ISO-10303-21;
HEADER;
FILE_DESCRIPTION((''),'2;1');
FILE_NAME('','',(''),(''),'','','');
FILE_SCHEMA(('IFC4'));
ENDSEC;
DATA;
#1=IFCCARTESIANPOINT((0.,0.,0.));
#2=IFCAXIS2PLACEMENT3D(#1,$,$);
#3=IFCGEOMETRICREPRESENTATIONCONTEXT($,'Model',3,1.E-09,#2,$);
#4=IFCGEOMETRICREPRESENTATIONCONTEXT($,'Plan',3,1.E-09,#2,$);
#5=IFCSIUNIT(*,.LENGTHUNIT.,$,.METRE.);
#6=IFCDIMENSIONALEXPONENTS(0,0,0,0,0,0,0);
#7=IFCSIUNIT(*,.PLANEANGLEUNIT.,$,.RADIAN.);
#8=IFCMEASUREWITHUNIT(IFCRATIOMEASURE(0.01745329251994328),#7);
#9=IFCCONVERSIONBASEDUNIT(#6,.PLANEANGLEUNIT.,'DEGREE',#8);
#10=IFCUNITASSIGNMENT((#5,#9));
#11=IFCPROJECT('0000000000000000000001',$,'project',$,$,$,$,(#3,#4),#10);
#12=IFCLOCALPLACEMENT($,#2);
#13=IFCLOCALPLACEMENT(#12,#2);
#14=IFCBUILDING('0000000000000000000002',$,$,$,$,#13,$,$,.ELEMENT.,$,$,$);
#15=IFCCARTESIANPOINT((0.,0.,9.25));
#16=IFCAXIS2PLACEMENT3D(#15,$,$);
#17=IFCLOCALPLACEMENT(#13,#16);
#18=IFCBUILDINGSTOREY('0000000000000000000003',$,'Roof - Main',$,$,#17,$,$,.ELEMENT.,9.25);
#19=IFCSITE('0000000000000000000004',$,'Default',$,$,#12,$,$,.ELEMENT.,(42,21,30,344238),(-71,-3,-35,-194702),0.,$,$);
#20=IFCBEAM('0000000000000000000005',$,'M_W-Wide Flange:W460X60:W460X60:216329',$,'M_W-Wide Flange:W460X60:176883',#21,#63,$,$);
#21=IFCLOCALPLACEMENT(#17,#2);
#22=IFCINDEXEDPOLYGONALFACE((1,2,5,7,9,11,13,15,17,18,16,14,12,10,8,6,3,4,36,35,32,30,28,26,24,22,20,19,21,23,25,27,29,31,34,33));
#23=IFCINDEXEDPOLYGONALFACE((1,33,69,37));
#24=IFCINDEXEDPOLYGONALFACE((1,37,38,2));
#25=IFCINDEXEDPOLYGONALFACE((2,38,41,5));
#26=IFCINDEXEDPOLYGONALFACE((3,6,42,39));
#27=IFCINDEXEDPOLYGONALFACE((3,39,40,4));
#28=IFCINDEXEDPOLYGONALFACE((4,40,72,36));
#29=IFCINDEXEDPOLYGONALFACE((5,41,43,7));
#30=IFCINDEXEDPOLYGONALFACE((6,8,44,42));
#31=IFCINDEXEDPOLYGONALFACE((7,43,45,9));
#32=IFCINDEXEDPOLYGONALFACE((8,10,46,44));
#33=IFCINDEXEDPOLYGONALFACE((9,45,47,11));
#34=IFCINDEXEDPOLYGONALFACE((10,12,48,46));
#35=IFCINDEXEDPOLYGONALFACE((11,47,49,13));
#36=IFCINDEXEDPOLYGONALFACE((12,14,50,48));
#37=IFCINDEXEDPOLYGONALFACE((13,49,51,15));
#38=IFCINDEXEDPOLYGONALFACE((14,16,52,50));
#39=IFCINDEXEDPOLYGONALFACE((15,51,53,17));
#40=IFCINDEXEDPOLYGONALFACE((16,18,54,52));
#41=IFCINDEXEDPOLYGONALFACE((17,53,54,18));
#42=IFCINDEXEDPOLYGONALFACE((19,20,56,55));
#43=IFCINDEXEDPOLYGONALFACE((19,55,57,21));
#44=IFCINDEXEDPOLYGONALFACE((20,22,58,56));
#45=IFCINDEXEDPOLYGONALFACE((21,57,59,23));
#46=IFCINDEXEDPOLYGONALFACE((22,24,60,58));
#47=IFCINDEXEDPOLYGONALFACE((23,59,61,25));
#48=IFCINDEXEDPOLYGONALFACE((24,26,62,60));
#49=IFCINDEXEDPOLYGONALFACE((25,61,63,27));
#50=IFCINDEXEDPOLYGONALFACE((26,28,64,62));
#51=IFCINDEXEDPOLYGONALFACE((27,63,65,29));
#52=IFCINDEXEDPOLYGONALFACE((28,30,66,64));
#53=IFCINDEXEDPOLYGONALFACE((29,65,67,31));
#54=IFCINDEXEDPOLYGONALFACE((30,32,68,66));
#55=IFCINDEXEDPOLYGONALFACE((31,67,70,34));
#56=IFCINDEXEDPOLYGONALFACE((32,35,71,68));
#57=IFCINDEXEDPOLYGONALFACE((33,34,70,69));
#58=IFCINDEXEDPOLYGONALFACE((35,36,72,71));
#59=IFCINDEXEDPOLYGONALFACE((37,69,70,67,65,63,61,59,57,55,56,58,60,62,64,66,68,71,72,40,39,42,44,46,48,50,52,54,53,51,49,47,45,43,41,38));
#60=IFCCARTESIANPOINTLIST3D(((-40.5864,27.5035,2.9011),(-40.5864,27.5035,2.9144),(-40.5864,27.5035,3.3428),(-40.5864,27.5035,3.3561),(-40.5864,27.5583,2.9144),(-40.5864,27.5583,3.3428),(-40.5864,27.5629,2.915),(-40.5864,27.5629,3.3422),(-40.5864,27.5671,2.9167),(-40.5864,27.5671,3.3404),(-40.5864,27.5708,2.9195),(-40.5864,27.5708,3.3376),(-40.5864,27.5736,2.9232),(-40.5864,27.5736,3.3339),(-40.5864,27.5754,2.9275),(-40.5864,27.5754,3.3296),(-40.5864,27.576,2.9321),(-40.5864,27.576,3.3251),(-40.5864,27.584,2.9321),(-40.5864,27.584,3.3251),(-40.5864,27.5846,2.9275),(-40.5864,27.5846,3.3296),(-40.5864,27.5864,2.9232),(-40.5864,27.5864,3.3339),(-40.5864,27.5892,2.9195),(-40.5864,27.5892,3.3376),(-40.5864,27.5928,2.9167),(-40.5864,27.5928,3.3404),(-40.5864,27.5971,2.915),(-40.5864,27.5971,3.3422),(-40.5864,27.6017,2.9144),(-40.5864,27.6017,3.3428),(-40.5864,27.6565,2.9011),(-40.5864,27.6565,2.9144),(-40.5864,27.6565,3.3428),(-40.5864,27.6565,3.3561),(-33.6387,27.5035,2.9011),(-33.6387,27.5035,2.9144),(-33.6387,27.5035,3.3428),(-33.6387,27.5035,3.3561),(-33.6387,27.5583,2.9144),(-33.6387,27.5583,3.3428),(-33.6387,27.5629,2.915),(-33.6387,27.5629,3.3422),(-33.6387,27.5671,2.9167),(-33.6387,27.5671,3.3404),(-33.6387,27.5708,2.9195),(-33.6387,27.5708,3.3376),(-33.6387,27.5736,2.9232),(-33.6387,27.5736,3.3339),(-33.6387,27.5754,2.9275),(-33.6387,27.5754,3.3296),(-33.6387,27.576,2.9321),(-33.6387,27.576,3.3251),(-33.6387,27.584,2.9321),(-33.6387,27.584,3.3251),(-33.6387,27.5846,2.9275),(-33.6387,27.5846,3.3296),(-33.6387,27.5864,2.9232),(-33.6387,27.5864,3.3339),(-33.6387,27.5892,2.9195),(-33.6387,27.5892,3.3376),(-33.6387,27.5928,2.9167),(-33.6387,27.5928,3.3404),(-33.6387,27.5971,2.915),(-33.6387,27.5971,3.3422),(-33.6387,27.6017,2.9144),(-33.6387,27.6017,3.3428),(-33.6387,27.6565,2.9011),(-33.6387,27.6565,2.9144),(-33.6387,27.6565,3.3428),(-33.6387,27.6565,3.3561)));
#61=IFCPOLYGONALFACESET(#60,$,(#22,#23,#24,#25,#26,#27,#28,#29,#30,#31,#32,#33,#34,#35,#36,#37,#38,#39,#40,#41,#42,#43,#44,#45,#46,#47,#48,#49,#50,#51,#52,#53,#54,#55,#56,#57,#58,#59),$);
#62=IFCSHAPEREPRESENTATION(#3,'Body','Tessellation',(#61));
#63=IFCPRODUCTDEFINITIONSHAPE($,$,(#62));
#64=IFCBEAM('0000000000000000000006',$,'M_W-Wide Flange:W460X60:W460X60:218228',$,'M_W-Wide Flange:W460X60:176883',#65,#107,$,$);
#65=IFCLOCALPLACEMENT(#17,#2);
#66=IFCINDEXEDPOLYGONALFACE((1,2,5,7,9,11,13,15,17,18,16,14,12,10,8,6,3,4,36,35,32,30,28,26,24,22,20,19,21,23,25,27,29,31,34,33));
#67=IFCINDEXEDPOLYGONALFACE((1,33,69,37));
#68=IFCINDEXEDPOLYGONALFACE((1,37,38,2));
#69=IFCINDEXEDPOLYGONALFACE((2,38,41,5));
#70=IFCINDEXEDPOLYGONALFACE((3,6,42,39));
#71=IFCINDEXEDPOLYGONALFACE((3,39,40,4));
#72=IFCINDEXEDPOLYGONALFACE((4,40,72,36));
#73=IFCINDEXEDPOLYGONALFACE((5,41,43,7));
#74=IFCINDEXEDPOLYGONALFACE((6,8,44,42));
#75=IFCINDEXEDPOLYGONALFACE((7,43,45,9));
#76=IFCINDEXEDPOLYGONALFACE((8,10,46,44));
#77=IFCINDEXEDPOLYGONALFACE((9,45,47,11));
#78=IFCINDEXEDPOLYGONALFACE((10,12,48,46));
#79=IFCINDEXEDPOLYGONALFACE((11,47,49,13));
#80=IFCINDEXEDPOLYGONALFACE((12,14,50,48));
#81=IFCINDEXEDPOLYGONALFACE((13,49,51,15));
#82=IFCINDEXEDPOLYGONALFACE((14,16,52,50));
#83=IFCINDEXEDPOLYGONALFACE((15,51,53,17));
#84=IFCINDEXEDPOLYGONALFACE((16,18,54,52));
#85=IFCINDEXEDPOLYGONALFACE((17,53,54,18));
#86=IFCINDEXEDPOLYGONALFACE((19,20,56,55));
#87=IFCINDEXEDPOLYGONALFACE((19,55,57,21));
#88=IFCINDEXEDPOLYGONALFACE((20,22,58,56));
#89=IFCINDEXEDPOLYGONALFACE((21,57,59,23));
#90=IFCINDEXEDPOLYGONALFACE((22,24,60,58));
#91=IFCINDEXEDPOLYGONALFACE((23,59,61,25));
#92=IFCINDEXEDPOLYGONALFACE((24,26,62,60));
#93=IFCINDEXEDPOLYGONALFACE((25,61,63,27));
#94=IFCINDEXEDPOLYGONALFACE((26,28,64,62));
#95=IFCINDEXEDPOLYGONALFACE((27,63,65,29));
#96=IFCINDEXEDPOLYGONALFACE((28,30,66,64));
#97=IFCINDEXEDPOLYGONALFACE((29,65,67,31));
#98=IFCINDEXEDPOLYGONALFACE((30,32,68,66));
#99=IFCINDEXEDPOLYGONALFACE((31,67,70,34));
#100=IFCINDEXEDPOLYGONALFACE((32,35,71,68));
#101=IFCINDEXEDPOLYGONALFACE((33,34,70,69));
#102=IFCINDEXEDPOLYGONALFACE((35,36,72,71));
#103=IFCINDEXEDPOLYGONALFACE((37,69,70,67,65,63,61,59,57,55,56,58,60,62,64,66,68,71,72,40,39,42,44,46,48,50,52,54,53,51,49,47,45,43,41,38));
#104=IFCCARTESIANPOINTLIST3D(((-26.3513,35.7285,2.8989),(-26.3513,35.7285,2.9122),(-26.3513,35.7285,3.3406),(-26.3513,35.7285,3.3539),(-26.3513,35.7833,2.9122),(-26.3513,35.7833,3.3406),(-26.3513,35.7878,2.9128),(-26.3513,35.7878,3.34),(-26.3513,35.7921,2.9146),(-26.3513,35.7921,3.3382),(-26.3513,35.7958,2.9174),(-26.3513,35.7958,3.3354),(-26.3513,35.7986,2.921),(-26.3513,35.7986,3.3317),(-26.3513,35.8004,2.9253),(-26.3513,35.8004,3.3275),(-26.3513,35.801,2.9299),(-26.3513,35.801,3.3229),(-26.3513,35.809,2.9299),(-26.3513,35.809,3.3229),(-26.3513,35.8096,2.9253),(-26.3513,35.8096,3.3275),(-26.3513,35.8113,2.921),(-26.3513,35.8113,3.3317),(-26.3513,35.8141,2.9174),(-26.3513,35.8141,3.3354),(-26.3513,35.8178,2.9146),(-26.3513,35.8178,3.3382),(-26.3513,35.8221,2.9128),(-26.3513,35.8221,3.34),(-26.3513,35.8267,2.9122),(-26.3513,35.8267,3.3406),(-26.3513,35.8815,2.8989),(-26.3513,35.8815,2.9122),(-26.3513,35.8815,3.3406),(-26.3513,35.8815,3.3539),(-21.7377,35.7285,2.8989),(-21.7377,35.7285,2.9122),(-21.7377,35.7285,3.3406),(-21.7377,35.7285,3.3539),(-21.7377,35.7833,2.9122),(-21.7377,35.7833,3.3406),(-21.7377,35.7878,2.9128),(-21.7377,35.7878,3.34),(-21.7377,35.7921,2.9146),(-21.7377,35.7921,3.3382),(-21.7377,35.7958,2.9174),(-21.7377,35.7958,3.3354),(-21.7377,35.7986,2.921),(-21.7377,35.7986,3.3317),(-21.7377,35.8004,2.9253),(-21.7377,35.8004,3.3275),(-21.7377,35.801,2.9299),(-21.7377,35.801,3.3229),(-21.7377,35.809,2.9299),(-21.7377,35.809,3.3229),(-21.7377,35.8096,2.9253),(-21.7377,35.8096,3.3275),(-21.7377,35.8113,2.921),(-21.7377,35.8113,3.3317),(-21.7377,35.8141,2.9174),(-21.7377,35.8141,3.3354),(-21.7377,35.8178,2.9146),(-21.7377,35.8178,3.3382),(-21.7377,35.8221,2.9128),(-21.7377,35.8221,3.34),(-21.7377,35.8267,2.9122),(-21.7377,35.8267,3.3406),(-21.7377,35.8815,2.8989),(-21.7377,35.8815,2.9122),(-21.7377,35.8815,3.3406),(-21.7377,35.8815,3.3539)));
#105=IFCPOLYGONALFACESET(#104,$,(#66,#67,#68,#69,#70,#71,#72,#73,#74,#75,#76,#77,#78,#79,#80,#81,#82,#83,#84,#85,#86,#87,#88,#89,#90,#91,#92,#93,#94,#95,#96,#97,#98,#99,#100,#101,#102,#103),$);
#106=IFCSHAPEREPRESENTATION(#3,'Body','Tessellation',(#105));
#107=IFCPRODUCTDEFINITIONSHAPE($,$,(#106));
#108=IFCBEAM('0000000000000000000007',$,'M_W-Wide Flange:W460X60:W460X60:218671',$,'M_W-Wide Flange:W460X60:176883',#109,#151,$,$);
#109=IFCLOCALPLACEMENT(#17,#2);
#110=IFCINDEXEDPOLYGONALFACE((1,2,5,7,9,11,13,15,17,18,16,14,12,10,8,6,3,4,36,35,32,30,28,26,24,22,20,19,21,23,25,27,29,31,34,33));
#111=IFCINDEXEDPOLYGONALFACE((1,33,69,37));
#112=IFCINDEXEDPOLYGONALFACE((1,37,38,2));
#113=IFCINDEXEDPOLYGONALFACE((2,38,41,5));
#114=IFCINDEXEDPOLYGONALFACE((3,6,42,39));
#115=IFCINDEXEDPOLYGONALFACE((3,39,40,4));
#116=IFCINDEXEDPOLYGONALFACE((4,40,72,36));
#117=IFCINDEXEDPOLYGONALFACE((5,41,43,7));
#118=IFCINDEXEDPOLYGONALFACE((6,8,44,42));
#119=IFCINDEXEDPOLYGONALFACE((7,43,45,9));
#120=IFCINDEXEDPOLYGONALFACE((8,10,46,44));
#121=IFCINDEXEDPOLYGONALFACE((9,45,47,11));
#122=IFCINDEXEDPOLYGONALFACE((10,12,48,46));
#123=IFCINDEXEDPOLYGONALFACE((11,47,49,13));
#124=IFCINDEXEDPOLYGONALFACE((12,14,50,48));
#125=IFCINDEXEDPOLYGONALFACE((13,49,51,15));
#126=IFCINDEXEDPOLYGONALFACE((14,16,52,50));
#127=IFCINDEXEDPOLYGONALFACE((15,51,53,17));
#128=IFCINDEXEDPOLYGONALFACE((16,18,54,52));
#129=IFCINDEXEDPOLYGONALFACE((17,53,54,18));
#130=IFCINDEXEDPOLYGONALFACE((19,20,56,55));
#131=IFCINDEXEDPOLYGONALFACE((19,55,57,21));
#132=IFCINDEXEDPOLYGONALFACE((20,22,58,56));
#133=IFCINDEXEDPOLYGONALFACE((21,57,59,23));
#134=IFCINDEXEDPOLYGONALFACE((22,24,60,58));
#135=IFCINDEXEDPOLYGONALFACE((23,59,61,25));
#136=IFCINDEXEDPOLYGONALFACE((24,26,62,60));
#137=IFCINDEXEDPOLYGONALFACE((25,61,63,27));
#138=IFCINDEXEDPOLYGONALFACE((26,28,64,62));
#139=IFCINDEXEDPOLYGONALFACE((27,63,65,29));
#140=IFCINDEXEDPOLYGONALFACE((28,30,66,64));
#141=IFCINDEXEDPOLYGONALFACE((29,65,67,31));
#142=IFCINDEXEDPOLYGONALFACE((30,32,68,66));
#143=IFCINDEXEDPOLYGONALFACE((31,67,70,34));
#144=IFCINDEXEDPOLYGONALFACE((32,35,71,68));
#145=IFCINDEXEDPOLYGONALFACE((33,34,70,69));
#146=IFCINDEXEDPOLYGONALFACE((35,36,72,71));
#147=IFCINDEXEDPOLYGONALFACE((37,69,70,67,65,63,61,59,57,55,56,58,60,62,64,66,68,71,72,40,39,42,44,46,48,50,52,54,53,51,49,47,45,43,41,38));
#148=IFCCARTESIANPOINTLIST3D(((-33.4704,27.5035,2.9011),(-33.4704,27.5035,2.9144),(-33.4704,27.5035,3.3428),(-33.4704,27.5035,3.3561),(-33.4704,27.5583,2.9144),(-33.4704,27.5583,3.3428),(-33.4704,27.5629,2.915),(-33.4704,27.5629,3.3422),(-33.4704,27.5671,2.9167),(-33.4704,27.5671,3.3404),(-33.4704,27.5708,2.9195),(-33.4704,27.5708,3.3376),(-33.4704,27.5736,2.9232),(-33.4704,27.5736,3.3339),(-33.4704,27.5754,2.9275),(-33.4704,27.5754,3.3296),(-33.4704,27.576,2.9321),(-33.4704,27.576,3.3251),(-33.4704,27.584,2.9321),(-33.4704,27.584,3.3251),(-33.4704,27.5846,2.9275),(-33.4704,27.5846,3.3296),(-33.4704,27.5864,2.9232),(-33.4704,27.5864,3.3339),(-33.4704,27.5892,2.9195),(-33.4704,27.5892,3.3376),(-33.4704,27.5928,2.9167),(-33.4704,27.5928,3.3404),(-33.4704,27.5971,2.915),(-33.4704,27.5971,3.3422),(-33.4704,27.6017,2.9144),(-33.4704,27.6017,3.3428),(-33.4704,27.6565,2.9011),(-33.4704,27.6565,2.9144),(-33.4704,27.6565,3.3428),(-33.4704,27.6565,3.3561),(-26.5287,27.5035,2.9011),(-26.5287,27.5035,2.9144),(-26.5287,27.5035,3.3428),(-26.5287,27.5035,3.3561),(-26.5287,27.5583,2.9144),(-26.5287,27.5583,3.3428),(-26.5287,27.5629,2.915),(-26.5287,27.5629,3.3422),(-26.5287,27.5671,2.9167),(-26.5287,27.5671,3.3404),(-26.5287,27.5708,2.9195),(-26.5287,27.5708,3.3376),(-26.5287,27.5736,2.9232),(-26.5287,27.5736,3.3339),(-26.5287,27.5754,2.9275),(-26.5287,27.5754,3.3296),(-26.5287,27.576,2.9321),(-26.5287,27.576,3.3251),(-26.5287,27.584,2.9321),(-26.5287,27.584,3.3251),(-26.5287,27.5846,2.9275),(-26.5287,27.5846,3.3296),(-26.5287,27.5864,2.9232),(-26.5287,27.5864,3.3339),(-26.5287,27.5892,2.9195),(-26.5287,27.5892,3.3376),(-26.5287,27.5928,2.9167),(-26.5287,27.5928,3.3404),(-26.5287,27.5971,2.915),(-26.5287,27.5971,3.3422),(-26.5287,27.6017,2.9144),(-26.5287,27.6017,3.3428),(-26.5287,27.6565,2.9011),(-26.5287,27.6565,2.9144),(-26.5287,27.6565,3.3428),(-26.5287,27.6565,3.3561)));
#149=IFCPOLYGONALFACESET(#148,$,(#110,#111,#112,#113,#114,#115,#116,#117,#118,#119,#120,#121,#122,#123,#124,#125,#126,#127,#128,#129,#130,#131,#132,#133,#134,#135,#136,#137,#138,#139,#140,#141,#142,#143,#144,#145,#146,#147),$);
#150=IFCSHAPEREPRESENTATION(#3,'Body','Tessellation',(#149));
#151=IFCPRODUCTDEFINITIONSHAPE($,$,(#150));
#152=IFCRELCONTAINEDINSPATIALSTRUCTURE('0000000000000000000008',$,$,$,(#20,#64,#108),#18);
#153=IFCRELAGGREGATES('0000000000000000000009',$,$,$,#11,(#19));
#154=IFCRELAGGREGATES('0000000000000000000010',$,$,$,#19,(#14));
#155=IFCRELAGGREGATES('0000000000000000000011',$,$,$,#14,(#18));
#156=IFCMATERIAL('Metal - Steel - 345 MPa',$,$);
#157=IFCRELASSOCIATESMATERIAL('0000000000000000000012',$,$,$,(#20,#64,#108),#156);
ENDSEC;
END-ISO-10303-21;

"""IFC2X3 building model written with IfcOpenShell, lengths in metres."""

from ifc_helpers import new_model, entity, si_unit, converted_unit, frame, frame_2d, origin, place, context, project, spatial, polyline, circle_curve, parameter, trimmed, segment, composite_curve, outline, extrude, material, element, save


model = new_model("IFC2X3")

# Units and contexts
model_context = context("Model", 3, precision=1e-09, world=origin())
plan_context = context("Plan", 3, precision=1e-09, world=origin())
ifc_project = project(units=[si_unit("LENGTHUNIT", "METRE"), converted_unit("PLANEANGLEUNIT", "DEGREE", entity("IfcRatioMeasure", 0.01745329251994328), si_unit("PLANEANGLEUNIT", "RADIAN"), dimensions=[0, 0, 0, 0, 0, 0, 0])], contexts=[model_context, plan_context])

# Site, building, storey
site_placement = place(None, origin())
site = spatial("IfcSite", under=ifc_project, at=site_placement, Name="Default", CompositionType="ELEMENT", RefLatitude=(42, 21, 30, 344238), RefLongitude=(-71, -3, -35, -194702), RefElevation=0.0)
building_placement = place(site_placement, origin())
building = spatial("IfcBuilding", under=site, at=building_placement, CompositionType="ELEMENT")
storey_placement = place(building_placement, frame((0.0, 0.0, 9.25)))
storey = spatial("IfcBuildingStorey", under=building, at=storey_placement, Name="Roof - Main", CompositionType="ELEMENT", Elevation=9.25)

# Shared definitions
ifc_material_1 = material(Name="Metal - Steel - 345 MPa")

# Beams
beam_1_placement = place(storey_placement, frame((-6.691, 27.58, 3.3561), z_axis=(0.0, 0.0, 1.0), x_axis=(0.0, -1.0, 0.0)))
element("IfcBeam", 1, at=beam_1_placement, inside=storey, material=ifc_material_1, Name="M_W-Wide Flange:W460X60:W460X60:216329", ObjectType="M_W-Wide Flange:W460X60:176883", context=model_context, shape_type="SweptSolid", body=[
    extrude(outline(composite_curve([segment(polyline([(0.2142, -0.0765), (0.2275, -0.0765)]), True, "CONTINUOUS"), segment(polyline([(0.2275, -0.0765), (0.2275, 0.0765)]), True, "CONTINUOUS"), segment(polyline([(0.2275, 0.0765), (0.2142, 0.0765)]), True, "CONTINUOUS"), segment(polyline([(0.2142, 0.0765), (0.2142, 0.0217)]), True, "CONTINUOUS"), segment(trimmed(circle_curve(frame_2d((0.1965, 0.0217), x_axis=(0.0, 1.0)), 0.0177), [parameter(180.0)], [parameter(270.0)], True, "PARAMETER"), False, "CONTINUOUS"), segment(polyline([(0.1965, 0.004), (-0.1965, 0.004)]), True, "CONTINUOUS"), segment(trimmed(circle_curve(frame_2d((-0.1965, 0.0217), x_axis=(0.0, 1.0)), 0.0177), [parameter(90.0)], [parameter(180.0)], True, "PARAMETER"), False, "CONTINUOUS"), segment(polyline([(-0.2142, 0.0217), (-0.2142, 0.0765)]), True, "CONTINUOUS"), segment(polyline([(-0.2142, 0.0765), (-0.2275, 0.0765)]), True, "CONTINUOUS"), segment(polyline([(-0.2275, 0.0765), (-0.2275, -0.0765)]), True, "CONTINUOUS"), segment(polyline([(-0.2275, -0.0765), (-0.2142, -0.0765)]), True, "CONTINUOUS"), segment(polyline([(-0.2142, -0.0765), (-0.2142, -0.0217)]), True, "CONTINUOUS"), segment(trimmed(circle_curve(frame_2d((-0.1965, -0.0217), x_axis=(0.0, 1.0)), 0.0177), [parameter(360.0)], [parameter(90.0)], True, "PARAMETER"), False, "CONTINUOUS"), segment(polyline([(-0.1965, -0.004), (0.1965, -0.004)]), True, "CONTINUOUS"), segment(trimmed(circle_curve(frame_2d((0.1965, -0.0217), x_axis=(0.0, 1.0)), 0.0177), [parameter(270.0)], [parameter(0.0)], True, "PARAMETER"), False, "CONTINUOUS"), segment(polyline([(0.2142, -0.0217), (0.2142, -0.0765)]), True, "CONTINUOUS")], self_intersect=False)), frame((0.0, -33.8954, -0.2275), z_axis=(0.0, 1.0, 0.0), x_axis=(0.0, 0.0, -1.0)), (0.0, 0.0, 1.0), 6.9477),
])
beam_2_placement = place(storey_placement, frame((-6.691, 35.805, 3.3539), z_axis=(0.0, 0.0, 1.0), x_axis=(0.0, -1.0, 0.0)))
element("IfcBeam", 2, at=beam_2_placement, inside=storey, material=ifc_material_1, Name="M_W-Wide Flange:W460X60:W460X60:218228", ObjectType="M_W-Wide Flange:W460X60:176883", context=model_context, shape_type="SweptSolid", body=[
    extrude(outline(composite_curve([segment(polyline([(-0.0765, -0.2142), (-0.0765, -0.2275)]), True, "CONTINUOUS"), segment(polyline([(-0.0765, -0.2275), (0.0765, -0.2275)]), True, "CONTINUOUS"), segment(polyline([(0.0765, -0.2275), (0.0765, -0.2142)]), True, "CONTINUOUS"), segment(polyline([(0.0765, -0.2142), (0.0217, -0.2142)]), True, "CONTINUOUS"), segment(trimmed(circle_curve(frame_2d((0.0217, -0.1965), x_axis=(1.0, 0.0)), 0.0177), [parameter(180.0)], [parameter(270.0)], True, "PARAMETER"), False, "CONTINUOUS"), segment(polyline([(0.004, -0.1965), (0.004, 0.1965)]), True, "CONTINUOUS"), segment(trimmed(circle_curve(frame_2d((0.0217, 0.1965), x_axis=(1.0, 0.0)), 0.0177), [parameter(90.0)], [parameter(180.0)], True, "PARAMETER"), False, "CONTINUOUS"), segment(polyline([(0.0217, 0.2142), (0.0765, 0.2142)]), True, "CONTINUOUS"), segment(polyline([(0.0765, 0.2142), (0.0765, 0.2275)]), True, "CONTINUOUS"), segment(polyline([(0.0765, 0.2275), (-0.0765, 0.2275)]), True, "CONTINUOUS"), segment(polyline([(-0.0765, 0.2275), (-0.0765, 0.2142)]), True, "CONTINUOUS"), segment(polyline([(-0.0765, 0.2142), (-0.0217, 0.2142)]), True, "CONTINUOUS"), segment(trimmed(circle_curve(frame_2d((-0.0217, 0.1965), x_axis=(1.0, 0.0)), 0.0177), [parameter(360.0)], [parameter(90.0)], True, "PARAMETER"), False, "CONTINUOUS"), segment(polyline([(-0.004, 0.1965), (-0.004, -0.1965)]), True, "CONTINUOUS"), segment(trimmed(circle_curve(frame_2d((-0.0217, -0.1965), x_axis=(1.0, 0.0)), 0.0177), [parameter(270.0)], [parameter(0.0)], True, "PARAMETER"), False, "CONTINUOUS"), segment(polyline([(-0.0217, -0.2142), (-0.0765, -0.2142)]), True, "CONTINUOUS")], self_intersect=False)), frame((0.0, -19.6603, -0.2275), z_axis=(0.0, -1.0, 0.0), x_axis=(1.0, 0.0, 0.0)), (0.0, 0.0, -1.0), 4.6136),
])
beam_3_placement = place(storey_placement, frame((-6.691, 27.58, 3.3561), z_axis=(0.0, 0.0, 1.0), x_axis=(0.0, -1.0, 0.0)))
element("IfcBeam", 3, at=beam_3_placement, inside=storey, material=ifc_material_1, Name="M_W-Wide Flange:W460X60:W460X60:218671", ObjectType="M_W-Wide Flange:W460X60:176883", context=model_context, shape_type="SweptSolid", body=[
    extrude(outline(composite_curve([segment(polyline([(0.2142, -0.0765), (0.2275, -0.0765)]), True, "CONTINUOUS"), segment(polyline([(0.2275, -0.0765), (0.2275, 0.0765)]), True, "CONTINUOUS"), segment(polyline([(0.2275, 0.0765), (0.2142, 0.0765)]), True, "CONTINUOUS"), segment(polyline([(0.2142, 0.0765), (0.2142, 0.0217)]), True, "CONTINUOUS"), segment(trimmed(circle_curve(frame_2d((0.1965, 0.0217), x_axis=(0.0, 1.0)), 0.0177), [parameter(180.0)], [parameter(270.0)], True, "PARAMETER"), False, "CONTINUOUS"), segment(polyline([(0.1965, 0.004), (-0.1965, 0.004)]), True, "CONTINUOUS"), segment(trimmed(circle_curve(frame_2d((-0.1965, 0.0217), x_axis=(0.0, 1.0)), 0.0177), [parameter(90.0)], [parameter(180.0)], True, "PARAMETER"), False, "CONTINUOUS"), segment(polyline([(-0.2142, 0.0217), (-0.2142, 0.0765)]), True, "CONTINUOUS"), segment(polyline([(-0.2142, 0.0765), (-0.2275, 0.0765)]), True, "CONTINUOUS"), segment(polyline([(-0.2275, 0.0765), (-0.2275, -0.0765)]), True, "CONTINUOUS"), segment(polyline([(-0.2275, -0.0765), (-0.2142, -0.0765)]), True, "CONTINUOUS"), segment(polyline([(-0.2142, -0.0765), (-0.2142, -0.0217)]), True, "CONTINUOUS"), segment(trimmed(circle_curve(frame_2d((-0.1965, -0.0217), x_axis=(0.0, 1.0)), 0.0177), [parameter(360.0)], [parameter(90.0)], True, "PARAMETER"), False, "CONTINUOUS"), segment(polyline([(-0.1965, -0.004), (0.1965, -0.004)]), True, "CONTINUOUS"), segment(trimmed(circle_curve(frame_2d((0.1965, -0.0217), x_axis=(0.0, 1.0)), 0.0177), [parameter(270.0)], [parameter(0.0)], True, "PARAMETER"), False, "CONTINUOUS"), segment(polyline([(0.2142, -0.0217), (0.2142, -0.0765)]), True, "CONTINUOUS")], self_intersect=False)), frame((0.0, -26.7794, -0.2275), z_axis=(0.0, 1.0, 0.0), x_axis=(0.0, 0.0, -1.0)), (0.0, 0.0, 1.0), 6.9417),
])

save(model, "model.ifc")
